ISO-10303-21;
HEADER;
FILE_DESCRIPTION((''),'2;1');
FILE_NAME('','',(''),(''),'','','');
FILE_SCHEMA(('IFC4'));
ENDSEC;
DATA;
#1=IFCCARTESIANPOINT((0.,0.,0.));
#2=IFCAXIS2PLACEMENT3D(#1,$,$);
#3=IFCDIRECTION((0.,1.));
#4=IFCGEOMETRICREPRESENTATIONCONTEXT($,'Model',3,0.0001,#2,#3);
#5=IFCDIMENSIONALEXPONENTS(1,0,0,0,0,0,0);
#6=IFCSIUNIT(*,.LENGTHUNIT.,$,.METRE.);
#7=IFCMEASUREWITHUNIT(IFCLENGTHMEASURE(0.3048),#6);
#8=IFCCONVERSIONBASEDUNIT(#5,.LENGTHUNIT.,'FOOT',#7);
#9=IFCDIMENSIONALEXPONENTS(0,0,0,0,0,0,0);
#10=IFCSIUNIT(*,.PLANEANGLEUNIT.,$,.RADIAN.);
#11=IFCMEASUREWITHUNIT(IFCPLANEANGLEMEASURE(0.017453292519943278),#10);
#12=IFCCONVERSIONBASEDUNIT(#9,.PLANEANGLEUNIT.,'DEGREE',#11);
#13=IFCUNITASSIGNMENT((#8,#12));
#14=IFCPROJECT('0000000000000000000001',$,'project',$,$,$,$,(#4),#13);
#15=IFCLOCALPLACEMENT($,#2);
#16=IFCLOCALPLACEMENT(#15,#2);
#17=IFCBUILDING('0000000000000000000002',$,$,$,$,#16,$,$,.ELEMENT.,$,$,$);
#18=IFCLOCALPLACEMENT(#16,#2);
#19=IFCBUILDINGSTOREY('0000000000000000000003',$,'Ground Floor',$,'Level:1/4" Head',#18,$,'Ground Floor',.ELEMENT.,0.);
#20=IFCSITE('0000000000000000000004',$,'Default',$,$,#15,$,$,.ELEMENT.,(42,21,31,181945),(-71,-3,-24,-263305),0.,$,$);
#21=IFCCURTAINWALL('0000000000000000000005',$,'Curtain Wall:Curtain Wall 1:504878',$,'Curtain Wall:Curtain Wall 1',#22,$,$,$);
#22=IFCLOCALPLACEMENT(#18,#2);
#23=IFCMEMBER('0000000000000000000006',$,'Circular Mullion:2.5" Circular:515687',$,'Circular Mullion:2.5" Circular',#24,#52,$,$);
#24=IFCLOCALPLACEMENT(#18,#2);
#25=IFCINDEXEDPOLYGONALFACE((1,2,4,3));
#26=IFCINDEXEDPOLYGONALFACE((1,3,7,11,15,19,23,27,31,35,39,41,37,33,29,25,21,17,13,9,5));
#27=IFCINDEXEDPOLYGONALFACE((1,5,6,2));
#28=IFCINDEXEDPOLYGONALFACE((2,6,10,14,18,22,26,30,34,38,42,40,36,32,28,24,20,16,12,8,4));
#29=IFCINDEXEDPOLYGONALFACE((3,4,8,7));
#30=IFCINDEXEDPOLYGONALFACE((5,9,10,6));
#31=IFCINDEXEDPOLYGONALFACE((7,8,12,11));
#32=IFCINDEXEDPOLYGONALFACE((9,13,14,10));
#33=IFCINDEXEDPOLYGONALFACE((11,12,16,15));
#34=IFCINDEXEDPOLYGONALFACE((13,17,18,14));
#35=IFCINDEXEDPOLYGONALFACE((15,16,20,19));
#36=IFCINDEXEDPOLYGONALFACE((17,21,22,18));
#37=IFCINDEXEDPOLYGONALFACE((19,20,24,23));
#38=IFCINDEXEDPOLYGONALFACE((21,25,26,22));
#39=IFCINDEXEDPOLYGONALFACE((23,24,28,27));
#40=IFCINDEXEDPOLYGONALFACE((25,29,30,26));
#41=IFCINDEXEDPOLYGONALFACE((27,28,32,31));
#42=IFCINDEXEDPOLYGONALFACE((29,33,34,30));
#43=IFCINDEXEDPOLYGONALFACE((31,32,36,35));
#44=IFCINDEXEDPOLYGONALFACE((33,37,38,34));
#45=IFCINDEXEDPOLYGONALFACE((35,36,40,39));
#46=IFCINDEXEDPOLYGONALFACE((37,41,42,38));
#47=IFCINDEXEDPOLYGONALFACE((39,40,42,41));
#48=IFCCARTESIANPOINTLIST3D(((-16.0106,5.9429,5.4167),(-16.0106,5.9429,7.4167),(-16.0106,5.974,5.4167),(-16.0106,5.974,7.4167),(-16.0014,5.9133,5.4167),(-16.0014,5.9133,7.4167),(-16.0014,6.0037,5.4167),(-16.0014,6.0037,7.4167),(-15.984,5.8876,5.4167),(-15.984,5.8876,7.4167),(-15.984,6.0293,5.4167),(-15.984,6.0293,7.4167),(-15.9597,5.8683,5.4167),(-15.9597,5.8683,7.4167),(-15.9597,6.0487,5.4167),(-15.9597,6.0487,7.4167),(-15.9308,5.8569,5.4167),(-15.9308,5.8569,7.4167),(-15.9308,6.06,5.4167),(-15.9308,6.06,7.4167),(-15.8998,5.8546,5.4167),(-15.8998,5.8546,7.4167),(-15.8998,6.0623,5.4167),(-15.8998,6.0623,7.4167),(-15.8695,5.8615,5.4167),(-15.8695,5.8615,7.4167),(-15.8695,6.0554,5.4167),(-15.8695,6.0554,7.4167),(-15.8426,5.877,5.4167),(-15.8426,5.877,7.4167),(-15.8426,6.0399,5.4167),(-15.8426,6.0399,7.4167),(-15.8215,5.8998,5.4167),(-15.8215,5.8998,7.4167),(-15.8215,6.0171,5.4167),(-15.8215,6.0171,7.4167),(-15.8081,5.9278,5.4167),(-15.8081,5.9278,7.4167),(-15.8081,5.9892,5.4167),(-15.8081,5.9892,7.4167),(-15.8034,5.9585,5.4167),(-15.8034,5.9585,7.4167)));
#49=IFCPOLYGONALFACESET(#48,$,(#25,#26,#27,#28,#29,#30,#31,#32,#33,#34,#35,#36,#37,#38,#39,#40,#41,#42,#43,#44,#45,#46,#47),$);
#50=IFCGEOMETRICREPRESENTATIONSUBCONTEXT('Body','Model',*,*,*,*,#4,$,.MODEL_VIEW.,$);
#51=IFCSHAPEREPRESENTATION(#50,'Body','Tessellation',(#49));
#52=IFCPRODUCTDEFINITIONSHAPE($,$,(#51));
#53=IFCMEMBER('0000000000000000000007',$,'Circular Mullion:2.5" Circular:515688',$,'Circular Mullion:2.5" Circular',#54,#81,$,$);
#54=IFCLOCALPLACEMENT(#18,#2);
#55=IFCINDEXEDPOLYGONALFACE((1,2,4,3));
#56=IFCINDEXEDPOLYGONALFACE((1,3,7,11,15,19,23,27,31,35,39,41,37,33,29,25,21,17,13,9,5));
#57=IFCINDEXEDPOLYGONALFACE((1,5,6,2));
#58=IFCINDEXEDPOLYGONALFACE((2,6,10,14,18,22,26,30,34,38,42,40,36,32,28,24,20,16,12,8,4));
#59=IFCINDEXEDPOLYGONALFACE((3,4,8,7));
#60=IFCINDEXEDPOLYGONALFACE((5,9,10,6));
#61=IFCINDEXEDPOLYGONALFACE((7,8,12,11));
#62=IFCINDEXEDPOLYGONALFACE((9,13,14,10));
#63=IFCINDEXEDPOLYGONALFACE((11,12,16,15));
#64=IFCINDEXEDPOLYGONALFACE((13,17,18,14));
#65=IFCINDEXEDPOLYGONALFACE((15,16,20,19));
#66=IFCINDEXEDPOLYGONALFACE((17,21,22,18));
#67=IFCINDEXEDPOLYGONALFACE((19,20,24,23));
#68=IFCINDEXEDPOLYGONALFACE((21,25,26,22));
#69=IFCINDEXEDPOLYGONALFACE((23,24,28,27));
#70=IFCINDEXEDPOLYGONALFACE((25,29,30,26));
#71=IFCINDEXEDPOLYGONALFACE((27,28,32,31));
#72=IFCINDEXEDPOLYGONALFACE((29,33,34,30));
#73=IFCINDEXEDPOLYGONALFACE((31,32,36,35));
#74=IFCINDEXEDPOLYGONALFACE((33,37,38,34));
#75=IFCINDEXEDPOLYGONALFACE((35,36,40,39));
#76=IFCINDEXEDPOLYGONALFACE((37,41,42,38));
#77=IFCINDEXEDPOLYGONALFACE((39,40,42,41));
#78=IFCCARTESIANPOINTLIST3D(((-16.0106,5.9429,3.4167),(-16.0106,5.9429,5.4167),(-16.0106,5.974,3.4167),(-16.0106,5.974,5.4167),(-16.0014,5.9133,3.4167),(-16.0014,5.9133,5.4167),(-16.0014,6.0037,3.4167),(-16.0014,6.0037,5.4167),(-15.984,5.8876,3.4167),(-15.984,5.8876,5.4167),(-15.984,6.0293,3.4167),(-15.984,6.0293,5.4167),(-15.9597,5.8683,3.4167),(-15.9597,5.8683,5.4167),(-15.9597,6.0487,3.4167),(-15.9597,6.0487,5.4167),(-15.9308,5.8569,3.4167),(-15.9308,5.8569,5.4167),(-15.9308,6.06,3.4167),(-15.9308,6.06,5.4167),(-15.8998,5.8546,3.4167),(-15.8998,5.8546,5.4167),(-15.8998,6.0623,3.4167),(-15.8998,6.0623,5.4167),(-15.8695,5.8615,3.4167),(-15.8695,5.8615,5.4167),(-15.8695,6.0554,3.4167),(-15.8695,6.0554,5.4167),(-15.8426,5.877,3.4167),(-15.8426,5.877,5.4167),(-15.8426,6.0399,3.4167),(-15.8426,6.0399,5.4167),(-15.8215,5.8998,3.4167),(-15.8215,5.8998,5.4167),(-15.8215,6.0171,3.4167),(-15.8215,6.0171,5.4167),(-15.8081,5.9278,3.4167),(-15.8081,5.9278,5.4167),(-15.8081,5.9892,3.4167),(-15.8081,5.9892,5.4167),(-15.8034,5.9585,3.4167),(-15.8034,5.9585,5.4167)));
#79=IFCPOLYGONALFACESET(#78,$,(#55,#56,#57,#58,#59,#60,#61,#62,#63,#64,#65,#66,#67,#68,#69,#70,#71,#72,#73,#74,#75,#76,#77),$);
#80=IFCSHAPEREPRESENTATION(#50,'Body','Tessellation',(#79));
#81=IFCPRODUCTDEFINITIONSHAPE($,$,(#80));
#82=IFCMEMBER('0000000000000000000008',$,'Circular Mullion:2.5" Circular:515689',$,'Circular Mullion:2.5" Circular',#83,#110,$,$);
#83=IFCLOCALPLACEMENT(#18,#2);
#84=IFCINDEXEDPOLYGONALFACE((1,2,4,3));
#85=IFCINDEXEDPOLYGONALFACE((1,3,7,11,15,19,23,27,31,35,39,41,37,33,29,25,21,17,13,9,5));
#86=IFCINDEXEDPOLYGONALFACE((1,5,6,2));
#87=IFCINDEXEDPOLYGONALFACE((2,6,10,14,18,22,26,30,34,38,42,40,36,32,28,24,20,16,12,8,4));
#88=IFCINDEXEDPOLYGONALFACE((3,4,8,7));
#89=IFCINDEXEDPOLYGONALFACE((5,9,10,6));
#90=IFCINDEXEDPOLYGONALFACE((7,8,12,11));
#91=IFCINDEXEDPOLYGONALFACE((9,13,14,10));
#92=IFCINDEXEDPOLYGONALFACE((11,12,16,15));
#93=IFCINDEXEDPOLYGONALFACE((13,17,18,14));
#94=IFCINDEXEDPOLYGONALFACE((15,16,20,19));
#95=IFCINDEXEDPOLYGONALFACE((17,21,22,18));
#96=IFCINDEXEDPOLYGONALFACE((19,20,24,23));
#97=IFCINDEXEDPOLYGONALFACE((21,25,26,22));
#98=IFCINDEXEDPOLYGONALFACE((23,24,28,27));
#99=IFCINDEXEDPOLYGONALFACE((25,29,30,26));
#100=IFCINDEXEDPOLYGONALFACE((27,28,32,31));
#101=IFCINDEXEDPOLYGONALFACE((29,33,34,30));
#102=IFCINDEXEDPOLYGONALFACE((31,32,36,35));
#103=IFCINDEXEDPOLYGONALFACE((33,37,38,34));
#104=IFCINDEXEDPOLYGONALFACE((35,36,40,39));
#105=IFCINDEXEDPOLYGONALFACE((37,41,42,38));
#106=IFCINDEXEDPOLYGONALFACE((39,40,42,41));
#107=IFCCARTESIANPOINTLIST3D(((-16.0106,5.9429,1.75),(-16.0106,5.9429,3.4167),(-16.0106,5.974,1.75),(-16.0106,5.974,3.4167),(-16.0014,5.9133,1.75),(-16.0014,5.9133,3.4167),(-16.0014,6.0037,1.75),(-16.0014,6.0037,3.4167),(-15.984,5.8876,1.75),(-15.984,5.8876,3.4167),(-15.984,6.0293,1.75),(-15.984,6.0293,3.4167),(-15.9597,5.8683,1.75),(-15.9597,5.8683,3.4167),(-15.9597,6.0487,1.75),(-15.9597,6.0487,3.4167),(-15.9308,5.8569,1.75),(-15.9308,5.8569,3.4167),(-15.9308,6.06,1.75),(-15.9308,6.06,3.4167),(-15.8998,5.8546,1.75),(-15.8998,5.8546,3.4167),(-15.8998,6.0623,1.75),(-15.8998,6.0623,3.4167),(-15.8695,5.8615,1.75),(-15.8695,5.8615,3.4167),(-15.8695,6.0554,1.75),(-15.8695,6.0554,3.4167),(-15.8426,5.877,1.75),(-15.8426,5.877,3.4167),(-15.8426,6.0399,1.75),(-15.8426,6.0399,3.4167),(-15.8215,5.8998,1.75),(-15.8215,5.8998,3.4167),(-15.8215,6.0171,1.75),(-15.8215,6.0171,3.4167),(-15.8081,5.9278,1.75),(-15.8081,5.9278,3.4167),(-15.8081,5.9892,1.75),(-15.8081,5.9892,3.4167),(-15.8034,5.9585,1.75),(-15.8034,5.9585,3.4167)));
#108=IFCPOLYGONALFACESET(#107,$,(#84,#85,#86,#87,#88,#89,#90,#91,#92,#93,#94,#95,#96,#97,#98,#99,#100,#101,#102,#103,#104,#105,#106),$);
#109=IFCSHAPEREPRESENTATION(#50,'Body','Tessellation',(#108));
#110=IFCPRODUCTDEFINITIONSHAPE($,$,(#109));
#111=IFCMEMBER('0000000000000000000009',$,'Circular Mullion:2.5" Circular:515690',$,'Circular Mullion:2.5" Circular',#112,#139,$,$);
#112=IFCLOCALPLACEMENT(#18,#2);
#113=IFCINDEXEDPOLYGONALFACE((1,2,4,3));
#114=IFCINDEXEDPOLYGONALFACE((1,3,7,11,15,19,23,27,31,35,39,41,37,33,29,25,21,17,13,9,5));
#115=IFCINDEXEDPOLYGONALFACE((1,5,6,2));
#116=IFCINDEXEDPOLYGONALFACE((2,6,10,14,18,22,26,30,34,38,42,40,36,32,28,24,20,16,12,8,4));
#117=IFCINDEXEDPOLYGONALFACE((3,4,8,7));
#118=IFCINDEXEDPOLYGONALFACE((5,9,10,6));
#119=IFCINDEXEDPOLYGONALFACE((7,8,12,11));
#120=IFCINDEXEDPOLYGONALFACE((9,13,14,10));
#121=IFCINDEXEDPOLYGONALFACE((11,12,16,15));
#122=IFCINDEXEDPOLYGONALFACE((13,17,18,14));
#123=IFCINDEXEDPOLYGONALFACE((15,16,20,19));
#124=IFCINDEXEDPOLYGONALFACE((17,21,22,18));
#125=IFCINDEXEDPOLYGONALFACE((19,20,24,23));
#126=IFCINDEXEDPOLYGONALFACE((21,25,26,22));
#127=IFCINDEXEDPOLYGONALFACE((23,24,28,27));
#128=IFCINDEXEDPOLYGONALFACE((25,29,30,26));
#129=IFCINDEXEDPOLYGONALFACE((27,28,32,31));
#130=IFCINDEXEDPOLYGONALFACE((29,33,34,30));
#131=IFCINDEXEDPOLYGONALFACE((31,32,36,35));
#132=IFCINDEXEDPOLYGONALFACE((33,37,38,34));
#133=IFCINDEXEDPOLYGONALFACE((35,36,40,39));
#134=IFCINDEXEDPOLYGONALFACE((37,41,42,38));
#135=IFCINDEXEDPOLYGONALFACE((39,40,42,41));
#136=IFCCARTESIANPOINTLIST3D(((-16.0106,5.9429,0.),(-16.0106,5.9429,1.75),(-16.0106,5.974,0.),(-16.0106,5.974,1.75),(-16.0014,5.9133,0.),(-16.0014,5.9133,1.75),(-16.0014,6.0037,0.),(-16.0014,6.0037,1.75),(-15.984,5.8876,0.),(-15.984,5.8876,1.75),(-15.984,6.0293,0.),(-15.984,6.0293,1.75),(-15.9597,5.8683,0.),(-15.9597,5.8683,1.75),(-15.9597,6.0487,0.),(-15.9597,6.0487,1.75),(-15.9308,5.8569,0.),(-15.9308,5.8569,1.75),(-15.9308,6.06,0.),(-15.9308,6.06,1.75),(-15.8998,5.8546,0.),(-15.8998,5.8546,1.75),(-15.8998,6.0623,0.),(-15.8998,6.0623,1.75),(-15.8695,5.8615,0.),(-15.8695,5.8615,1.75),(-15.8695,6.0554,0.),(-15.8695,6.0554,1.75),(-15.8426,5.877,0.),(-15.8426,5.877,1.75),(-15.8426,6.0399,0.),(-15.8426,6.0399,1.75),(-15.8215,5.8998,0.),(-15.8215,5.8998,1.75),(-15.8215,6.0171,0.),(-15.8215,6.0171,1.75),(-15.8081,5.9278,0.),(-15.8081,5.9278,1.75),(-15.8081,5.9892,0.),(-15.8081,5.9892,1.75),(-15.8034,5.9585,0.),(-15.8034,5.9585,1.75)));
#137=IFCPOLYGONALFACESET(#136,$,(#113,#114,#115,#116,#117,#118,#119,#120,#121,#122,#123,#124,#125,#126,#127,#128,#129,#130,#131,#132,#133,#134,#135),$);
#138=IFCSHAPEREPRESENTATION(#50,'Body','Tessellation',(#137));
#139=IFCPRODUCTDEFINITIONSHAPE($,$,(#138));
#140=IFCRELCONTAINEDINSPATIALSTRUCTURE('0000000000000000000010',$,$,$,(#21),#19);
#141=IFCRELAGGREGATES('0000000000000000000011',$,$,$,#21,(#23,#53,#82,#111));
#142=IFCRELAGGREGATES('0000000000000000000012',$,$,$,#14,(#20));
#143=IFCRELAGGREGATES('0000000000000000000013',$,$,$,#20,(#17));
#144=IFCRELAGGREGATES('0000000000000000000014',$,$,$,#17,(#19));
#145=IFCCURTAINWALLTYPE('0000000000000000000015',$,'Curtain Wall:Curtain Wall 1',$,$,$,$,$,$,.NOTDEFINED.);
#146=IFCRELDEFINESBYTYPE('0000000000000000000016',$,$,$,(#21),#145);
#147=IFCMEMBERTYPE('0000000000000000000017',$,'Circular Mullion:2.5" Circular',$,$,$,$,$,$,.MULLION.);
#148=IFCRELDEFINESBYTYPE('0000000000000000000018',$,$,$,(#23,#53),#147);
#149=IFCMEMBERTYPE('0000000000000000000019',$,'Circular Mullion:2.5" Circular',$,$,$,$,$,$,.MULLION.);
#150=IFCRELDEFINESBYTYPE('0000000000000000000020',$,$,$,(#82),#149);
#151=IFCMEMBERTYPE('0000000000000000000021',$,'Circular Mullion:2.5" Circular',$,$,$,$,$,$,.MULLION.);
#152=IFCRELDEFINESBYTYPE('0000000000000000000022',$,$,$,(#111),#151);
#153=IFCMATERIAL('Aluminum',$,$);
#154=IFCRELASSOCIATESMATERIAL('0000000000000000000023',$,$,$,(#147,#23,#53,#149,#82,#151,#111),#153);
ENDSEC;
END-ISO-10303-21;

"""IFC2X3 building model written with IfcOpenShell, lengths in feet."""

from ifc_helpers import new_model, entity, si_unit, converted_unit, direction, frame, frame_2d, origin, place, context, subcontext, project, spatial, circle, extrude, source, transform, mapped, material, type_object, type_shapes, element, aggregate, save


model = new_model("IFC2X3")

# Units and contexts
model_context = context("Model", 3, precision=0.0001, world=origin(), true_north=direction((0.0, 1.0)))
body_context = subcontext(model_context, "Body", "Model", "MODEL_VIEW")
ifc_project = project(units=[converted_unit("LENGTHUNIT", "FOOT", entity("IfcLengthMeasure", 0.3048), si_unit("LENGTHUNIT", "METRE"), dimensions=[1, 0, 0, 0, 0, 0, 0]), converted_unit("PLANEANGLEUNIT", "DEGREE", entity("IfcPlaneAngleMeasure", 0.017453292519943278), si_unit("PLANEANGLEUNIT", "RADIAN"), dimensions=[0, 0, 0, 0, 0, 0, 0])], contexts=[model_context])

# Site, building, storey
site_placement = place(None, origin())
site = spatial("IfcSite", under=ifc_project, at=site_placement, Name="Default", CompositionType="ELEMENT", RefLatitude=(42, 21, 31, 181945), RefLongitude=(-71, -3, -24, -263305), RefElevation=0.0)
building_placement = place(site_placement, origin())
building = spatial("IfcBuilding", under=site, at=building_placement, CompositionType="ELEMENT")
storey_placement = place(building_placement, origin())
storey = spatial("IfcBuildingStorey", under=building, at=storey_placement, Name="Ground Floor", ObjectType="Level:1/4\" Head", LongName="Ground Floor", CompositionType="ELEMENT", Elevation=0.0)

# Curtain wall, members
curtain_wall_type = type_object("IfcCurtainWallType", Name="Curtain Wall:Curtain Wall 1", PredefinedType="NOTDEFINED")
curtain_wall_placement = place(storey_placement, origin())
curtain_wall = element("IfcCurtainWall", 1, at=curtain_wall_placement, inside=storey, type_object=curtain_wall_type, Name="Curtain Wall:Curtain Wall 1:504878", ObjectType="Curtain Wall:Curtain Wall 1")
ifc_material_1 = material(Name="Aluminum")
member_type_1 = type_object("IfcMemberType", Name="Circular Mullion:2.5\" Circular", PredefinedType="MULLION", material=ifc_material_1)
shared_shape_1 = source(origin(), body_context, "Body", "SweptSolid", [
    extrude(circle(Radius=0.1042, at=frame_2d((0.0, 0.0), x_axis=(1.0, 0.0))), frame((-0.1042, 0.0, -2.0)), (0.0, 0.0, 1.0), 2.0),
])
type_shapes(member_type_1, [shared_shape_1])
member_1_placement = place(curtain_wall_placement, frame((-15.8034, 5.9585, 7.4167)))
member_1 = element("IfcMember", 2, at=member_1_placement, type_object=member_type_1, material=ifc_material_1, Name="Circular Mullion:2.5\" Circular:515687", ObjectType="Circular Mullion:2.5\" Circular", context=body_context, shape_type="MappedRepresentation", body=[
    mapped(shared_shape_1, transform((0.0, 0.0, 0.0), scale=1.0)),
])
member_2_placement = place(curtain_wall_placement, frame((-15.8034, 5.9585, 5.4167)))
member_2 = element("IfcMember", 3, at=member_2_placement, type_object=member_type_1, material=ifc_material_1, Name="Circular Mullion:2.5\" Circular:515688", ObjectType="Circular Mullion:2.5\" Circular", context=body_context, shape_type="MappedRepresentation", body=[
    mapped(shared_shape_1, transform((0.0, 0.0, 0.0), scale=1.0)),
])
member_type_2 = type_object("IfcMemberType", Name="Circular Mullion:2.5\" Circular", PredefinedType="MULLION", material=ifc_material_1)
shared_shape_2 = source(origin(), body_context, "Body", "SweptSolid", [
    extrude(circle(Radius=0.1042, at=frame_2d((0.0, 0.0), x_axis=(1.0, 0.0))), frame((-0.1042, 0.0, -1.6667)), (0.0, 0.0, 1.0), 1.6667),
])
type_shapes(member_type_2, [shared_shape_2])
member_3_placement = place(curtain_wall_placement, frame((-15.8034, 5.9585, 3.4167)))
member_3 = element("IfcMember", 4, at=member_3_placement, type_object=member_type_2, material=ifc_material_1, Name="Circular Mullion:2.5\" Circular:515689", ObjectType="Circular Mullion:2.5\" Circular", context=body_context, shape_type="MappedRepresentation", body=[
    mapped(shared_shape_2, transform((0.0, 0.0, 0.0), scale=1.0)),
])
member_type_3 = type_object("IfcMemberType", Name="Circular Mullion:2.5\" Circular", PredefinedType="MULLION", material=ifc_material_1)
shared_shape_3 = source(origin(), body_context, "Body", "SweptSolid", [
    extrude(circle(Radius=0.1042, at=frame_2d((0.0, 0.0), x_axis=(1.0, 0.0))), frame((-0.1042, 0.0, -1.75)), (0.0, 0.0, 1.0), 1.75),
])
type_shapes(member_type_3, [shared_shape_3])
member_4_placement = place(curtain_wall_placement, frame((-15.8034, 5.9585, 1.75)))
member_4 = element("IfcMember", 5, at=member_4_placement, type_object=member_type_3, material=ifc_material_1, Name="Circular Mullion:2.5\" Circular:515690", ObjectType="Circular Mullion:2.5\" Circular", context=body_context, shape_type="MappedRepresentation", body=[
    mapped(shared_shape_3, transform((0.0, 0.0, 0.0), scale=1.0)),
])
aggregate(curtain_wall, [member_1, member_2, member_3, member_4])

save(model, "model.ifc")
